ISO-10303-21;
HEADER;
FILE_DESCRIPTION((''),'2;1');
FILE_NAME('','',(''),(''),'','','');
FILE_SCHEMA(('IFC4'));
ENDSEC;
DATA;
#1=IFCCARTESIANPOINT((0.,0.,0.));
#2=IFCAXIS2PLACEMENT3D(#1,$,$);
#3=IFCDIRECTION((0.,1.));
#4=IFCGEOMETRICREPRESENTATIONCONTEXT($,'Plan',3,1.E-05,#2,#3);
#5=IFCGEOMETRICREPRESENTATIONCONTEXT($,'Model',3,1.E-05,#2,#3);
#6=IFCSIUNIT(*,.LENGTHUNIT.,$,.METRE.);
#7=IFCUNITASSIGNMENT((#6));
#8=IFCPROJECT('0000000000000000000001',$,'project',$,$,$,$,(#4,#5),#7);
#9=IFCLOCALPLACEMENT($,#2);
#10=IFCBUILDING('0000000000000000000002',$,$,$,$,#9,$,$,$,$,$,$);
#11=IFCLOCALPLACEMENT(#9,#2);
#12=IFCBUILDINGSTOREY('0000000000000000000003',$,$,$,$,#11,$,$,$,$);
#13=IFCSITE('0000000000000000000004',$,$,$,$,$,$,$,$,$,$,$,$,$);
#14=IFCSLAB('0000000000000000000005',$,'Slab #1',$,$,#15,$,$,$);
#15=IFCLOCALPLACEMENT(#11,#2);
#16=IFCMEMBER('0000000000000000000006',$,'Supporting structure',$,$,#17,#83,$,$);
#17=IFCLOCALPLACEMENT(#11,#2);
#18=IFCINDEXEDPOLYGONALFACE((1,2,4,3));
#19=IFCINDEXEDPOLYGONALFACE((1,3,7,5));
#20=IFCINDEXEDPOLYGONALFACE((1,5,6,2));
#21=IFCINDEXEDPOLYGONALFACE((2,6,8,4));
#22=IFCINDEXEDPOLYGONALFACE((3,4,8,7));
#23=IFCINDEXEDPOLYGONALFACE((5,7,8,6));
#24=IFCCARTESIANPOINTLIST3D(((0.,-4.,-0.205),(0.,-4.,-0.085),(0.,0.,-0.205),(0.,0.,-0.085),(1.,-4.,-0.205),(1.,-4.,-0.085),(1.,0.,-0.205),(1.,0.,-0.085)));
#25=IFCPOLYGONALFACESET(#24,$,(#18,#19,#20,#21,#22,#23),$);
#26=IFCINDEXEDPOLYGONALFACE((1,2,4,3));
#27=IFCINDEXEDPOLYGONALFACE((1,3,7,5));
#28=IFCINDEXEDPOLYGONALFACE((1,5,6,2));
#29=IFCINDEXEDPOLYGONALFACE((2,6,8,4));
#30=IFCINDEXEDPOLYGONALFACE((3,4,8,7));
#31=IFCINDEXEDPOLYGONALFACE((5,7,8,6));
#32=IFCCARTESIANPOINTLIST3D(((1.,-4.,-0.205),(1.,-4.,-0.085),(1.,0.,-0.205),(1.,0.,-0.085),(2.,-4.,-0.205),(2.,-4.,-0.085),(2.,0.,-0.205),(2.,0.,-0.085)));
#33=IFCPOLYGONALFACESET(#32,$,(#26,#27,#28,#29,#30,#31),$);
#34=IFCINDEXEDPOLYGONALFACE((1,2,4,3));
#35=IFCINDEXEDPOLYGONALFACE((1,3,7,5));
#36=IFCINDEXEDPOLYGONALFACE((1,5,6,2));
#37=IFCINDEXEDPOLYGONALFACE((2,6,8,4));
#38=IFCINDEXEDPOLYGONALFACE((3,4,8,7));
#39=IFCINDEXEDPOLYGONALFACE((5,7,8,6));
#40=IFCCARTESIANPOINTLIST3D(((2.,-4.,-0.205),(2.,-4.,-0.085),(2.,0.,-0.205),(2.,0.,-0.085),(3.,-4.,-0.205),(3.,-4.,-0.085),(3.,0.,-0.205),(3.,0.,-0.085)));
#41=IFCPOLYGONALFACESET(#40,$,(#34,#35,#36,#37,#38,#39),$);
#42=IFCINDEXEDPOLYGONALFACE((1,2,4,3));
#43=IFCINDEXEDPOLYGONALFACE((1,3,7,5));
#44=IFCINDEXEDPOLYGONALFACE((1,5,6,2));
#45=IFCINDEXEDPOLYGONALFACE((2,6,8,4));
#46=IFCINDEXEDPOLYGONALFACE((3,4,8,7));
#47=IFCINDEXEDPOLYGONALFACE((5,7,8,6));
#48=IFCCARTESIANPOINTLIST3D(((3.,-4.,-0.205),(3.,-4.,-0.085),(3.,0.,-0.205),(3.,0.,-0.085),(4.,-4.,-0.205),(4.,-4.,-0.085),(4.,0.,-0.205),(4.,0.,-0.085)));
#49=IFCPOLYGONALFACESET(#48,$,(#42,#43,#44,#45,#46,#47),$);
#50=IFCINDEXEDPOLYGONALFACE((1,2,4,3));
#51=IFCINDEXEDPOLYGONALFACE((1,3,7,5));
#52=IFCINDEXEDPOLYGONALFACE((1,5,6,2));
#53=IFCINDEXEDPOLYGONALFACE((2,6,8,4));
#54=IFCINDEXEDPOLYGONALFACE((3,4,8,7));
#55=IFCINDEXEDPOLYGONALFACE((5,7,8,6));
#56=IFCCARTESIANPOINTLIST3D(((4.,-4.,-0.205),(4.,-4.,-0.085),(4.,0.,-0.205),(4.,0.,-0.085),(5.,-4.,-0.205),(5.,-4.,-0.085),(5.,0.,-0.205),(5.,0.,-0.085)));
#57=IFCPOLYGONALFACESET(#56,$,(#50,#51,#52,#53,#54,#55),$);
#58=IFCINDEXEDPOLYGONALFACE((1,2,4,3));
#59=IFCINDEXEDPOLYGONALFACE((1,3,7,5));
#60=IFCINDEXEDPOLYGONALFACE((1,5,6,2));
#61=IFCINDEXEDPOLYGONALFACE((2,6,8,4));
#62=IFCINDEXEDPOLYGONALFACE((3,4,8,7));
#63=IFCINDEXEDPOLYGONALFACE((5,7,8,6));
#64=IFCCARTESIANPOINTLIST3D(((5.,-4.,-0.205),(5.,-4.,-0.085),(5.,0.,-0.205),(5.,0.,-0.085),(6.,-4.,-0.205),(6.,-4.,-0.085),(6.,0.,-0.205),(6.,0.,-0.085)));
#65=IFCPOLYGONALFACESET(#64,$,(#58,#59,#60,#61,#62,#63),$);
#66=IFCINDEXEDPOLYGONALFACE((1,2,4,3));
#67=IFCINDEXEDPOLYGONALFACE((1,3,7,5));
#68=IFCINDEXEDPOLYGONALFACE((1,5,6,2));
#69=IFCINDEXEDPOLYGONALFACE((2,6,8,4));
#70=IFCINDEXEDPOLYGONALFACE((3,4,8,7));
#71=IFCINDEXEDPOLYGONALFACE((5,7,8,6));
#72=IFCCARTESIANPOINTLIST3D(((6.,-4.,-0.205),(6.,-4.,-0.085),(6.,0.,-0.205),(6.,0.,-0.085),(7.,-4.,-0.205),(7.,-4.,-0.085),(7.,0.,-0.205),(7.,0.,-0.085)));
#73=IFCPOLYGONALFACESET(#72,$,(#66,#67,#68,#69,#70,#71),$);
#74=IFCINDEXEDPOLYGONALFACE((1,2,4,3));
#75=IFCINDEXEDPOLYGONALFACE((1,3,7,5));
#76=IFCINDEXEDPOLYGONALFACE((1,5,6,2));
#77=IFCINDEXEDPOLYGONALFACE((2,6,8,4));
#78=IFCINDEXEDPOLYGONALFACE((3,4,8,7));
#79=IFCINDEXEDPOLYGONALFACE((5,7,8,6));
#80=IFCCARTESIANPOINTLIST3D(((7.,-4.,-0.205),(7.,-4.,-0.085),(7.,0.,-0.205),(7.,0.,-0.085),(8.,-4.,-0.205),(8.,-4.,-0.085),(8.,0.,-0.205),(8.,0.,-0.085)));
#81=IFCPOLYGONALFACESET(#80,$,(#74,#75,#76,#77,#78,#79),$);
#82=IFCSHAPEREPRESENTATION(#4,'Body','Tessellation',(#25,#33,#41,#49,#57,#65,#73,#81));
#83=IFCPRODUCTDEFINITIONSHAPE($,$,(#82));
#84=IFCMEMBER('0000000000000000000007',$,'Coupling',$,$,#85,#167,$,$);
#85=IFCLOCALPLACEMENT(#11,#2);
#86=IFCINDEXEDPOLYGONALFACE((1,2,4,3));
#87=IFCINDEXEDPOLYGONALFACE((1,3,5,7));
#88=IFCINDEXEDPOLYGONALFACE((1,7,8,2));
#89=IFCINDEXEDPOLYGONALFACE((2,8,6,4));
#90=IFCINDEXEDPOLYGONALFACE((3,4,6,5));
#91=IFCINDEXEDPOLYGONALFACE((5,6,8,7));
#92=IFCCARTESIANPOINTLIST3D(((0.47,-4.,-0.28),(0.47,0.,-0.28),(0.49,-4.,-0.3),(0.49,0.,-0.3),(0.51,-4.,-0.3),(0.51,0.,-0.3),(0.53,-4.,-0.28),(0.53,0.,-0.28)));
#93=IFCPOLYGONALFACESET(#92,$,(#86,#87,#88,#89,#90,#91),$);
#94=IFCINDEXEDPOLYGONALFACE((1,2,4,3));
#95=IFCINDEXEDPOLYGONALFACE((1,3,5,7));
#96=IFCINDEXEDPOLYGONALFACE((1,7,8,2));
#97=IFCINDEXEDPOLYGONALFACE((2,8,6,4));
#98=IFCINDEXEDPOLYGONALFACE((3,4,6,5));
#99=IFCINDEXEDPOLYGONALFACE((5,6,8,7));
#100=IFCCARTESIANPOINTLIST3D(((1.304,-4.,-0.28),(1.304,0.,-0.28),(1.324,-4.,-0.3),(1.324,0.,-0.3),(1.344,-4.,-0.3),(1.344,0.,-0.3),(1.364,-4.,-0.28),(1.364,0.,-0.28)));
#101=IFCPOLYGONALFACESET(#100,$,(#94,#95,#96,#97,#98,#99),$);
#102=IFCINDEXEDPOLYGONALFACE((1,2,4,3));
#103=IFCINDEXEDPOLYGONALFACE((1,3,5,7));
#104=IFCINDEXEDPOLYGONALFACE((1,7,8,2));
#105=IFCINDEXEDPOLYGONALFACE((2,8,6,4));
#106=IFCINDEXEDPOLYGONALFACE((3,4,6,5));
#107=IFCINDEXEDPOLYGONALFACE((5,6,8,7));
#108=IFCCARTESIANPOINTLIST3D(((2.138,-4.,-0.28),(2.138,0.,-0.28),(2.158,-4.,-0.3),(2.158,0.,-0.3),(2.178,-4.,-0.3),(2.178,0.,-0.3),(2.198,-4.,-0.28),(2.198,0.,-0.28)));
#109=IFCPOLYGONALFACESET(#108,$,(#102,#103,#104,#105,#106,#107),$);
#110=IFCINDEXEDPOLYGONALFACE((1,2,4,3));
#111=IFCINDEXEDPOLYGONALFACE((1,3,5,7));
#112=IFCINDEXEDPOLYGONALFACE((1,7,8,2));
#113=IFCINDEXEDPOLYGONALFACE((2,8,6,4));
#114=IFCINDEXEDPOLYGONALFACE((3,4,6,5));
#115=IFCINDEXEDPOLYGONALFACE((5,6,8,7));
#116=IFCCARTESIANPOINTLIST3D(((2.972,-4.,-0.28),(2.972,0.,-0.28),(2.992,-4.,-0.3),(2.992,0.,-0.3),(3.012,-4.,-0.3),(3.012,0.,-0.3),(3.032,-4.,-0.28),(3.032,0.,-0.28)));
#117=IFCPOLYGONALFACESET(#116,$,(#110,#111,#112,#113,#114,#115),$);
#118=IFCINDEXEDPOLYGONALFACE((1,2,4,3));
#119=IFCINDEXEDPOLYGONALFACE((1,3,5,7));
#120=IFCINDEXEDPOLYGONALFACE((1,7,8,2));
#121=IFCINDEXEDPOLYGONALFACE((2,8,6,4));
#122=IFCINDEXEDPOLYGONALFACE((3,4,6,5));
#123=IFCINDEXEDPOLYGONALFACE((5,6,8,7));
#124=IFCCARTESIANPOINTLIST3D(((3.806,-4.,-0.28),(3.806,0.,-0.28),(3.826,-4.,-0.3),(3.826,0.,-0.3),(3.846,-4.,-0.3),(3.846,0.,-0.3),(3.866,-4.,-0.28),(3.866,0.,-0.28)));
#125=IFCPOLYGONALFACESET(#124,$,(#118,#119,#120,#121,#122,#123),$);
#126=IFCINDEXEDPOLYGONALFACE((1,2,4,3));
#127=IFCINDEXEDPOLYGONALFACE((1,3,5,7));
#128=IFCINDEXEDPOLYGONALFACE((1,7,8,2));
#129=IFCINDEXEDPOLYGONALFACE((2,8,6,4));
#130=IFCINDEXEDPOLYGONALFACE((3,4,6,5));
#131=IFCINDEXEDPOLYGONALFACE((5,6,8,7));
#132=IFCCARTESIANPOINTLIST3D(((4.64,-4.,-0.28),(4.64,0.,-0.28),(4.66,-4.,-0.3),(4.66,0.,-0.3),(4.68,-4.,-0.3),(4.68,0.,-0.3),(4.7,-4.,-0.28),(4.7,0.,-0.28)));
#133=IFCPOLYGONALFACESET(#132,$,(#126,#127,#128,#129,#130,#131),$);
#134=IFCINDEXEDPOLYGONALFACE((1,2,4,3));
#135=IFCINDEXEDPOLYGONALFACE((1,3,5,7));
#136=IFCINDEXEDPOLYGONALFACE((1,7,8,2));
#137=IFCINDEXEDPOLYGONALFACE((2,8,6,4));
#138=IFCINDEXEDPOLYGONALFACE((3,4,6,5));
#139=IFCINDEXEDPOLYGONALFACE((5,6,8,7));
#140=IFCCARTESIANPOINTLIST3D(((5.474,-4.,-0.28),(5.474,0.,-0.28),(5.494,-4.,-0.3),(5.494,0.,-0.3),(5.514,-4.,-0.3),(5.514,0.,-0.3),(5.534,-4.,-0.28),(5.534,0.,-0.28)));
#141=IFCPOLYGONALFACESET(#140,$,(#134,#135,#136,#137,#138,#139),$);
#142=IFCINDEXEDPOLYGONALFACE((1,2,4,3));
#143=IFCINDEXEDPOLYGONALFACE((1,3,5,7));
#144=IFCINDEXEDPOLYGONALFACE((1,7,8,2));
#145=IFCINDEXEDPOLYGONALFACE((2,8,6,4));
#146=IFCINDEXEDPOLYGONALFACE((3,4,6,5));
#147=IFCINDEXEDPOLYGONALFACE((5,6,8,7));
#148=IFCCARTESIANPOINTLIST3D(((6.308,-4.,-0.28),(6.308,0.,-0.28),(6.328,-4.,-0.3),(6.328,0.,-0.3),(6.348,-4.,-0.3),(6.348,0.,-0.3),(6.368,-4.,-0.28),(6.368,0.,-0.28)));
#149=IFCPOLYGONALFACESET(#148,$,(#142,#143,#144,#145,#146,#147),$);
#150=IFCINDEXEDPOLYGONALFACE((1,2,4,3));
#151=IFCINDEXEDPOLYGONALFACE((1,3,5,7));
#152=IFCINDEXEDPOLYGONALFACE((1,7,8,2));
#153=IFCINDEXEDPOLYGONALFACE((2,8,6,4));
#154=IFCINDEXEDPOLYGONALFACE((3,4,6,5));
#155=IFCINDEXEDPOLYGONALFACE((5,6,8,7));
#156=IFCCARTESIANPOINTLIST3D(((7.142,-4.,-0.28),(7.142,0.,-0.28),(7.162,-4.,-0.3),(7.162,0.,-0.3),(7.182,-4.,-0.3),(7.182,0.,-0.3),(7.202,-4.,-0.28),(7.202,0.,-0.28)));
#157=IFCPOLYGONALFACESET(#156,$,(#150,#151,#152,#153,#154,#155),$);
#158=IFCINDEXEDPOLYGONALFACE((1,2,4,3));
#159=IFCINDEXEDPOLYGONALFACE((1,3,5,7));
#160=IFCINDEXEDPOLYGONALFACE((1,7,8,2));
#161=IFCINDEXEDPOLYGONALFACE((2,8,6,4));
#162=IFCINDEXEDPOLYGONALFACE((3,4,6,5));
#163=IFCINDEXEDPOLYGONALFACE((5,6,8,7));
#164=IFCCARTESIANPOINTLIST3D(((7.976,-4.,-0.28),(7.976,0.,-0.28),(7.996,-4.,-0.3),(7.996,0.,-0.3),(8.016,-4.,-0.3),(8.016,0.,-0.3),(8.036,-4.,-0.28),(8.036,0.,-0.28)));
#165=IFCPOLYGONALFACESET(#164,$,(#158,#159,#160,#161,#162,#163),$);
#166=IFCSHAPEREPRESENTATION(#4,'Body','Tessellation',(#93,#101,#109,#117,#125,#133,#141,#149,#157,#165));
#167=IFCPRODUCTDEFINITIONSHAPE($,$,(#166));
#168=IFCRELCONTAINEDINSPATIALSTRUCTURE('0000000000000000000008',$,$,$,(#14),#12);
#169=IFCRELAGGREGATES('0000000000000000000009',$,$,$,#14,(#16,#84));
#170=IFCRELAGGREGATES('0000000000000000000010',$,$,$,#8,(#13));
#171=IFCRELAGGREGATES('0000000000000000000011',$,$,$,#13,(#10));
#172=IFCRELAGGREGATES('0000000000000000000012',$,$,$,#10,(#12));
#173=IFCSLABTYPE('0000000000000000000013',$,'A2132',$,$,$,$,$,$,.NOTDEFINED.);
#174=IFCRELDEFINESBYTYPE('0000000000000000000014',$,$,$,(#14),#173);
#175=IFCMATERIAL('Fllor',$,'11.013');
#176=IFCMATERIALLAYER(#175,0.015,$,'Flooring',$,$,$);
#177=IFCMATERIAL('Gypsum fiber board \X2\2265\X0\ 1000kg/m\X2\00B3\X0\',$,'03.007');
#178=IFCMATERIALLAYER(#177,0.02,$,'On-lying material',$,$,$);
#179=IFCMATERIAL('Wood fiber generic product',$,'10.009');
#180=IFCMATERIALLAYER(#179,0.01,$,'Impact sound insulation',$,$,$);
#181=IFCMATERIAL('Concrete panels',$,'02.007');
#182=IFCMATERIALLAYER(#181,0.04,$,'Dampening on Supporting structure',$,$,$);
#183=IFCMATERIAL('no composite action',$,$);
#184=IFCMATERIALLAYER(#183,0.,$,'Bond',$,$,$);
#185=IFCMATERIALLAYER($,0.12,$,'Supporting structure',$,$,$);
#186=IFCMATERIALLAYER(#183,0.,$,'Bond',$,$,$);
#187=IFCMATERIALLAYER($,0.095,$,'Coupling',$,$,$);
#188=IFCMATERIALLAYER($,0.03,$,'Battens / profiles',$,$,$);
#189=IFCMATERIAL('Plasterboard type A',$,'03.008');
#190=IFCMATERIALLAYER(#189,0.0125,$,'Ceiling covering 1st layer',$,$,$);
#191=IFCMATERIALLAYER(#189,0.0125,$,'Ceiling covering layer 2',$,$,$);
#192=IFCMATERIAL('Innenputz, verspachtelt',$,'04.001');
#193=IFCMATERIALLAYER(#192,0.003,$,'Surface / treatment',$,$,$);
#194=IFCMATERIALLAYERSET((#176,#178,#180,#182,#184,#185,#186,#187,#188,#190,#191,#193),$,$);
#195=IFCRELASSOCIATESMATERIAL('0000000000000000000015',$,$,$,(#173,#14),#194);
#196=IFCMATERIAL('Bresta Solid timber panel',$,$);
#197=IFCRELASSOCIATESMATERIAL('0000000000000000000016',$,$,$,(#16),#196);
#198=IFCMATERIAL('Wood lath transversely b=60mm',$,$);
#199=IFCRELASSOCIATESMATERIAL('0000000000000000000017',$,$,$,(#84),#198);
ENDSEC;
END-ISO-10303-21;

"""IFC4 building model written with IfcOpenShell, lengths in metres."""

from ifc_helpers import new_model, si_unit, direction, frame, frame_2d, origin, place, context, project, spatial, polyline, rectangle, outline, extrude, material, layer, layer_set, type_object, element, aggregate, save


model = new_model("IFC4")

# Units and contexts
plan_context = context("Plan", 3, precision=1e-05, world=origin(), true_north=direction((0.0, 1.0)))
model_context = context("Model", 3, precision=1e-05, world=origin(), true_north=direction((0.0, 1.0)))
ifc_project = project(units=[si_unit("LENGTHUNIT", "METRE")], contexts=[plan_context, model_context])

# Site, building, storey
site = spatial("IfcSite", under=ifc_project)
building_placement = place(None, origin())
building = spatial("IfcBuilding", under=site, at=building_placement)
storey_placement = place(building_placement, origin())
storey = spatial("IfcBuildingStorey", under=building, at=storey_placement)

# Slab, members
ifc_material_1 = material(Name="Fllor", Category="11.013")
ifc_layer_1 = layer(ifc_material_1, 0.015, Name="Flooring")
ifc_material_2 = material(Name="Gypsum fiber board ≥ 1000kg/m³", Category="03.007")
ifc_layer_2 = layer(ifc_material_2, 0.02, Name="On-lying material")
ifc_material_3 = material(Name="Wood fiber generic product", Category="10.009")
ifc_layer_3 = layer(ifc_material_3, 0.01, Name="Impact sound insulation")
ifc_material_4 = material(Name="Concrete panels", Category="02.007")
ifc_layer_4 = layer(ifc_material_4, 0.04, Name="Dampening on Supporting structure")
ifc_material_5 = material(Name="no composite action")
ifc_layer_5 = layer(ifc_material_5, 0.0, Name="Bond")
ifc_layer_6 = layer(None, 0.12, Name="Supporting structure")
ifc_layer_7 = layer(ifc_material_5, 0.0, Name="Bond")
ifc_layer_8 = layer(None, 0.095, Name="Coupling")
ifc_layer_9 = layer(None, 0.03, Name="Battens / profiles")
ifc_material_6 = material(Name="Plasterboard type A", Category="03.008")
ifc_layer_10 = layer(ifc_material_6, 0.0125, Name="Ceiling covering 1st layer")
ifc_layer_11 = layer(ifc_material_6, 0.0125, Name="Ceiling covering layer 2")
ifc_material_7 = material(Name="Innenputz, verspachtelt", Category="04.001")
ifc_layer_12 = layer(ifc_material_7, 0.003, Name="Surface / treatment")
ifc_layer_set = layer_set([ifc_layer_1, ifc_layer_2, ifc_layer_3, ifc_layer_4, ifc_layer_5, ifc_layer_6, ifc_layer_7, ifc_layer_8, ifc_layer_9, ifc_layer_10, ifc_layer_11, ifc_layer_12])
slab_type = type_object("IfcSlabType", Name="A2132", PredefinedType="NOTDEFINED", material=ifc_layer_set)
slab_placement = place(None, frame((0.0, 0.0, 0.0), z_axis=(0.0, 0.0, -1.0), x_axis=(1.0, 0.0, 0.0)))
slab = element("IfcSlab", 1, at=slab_placement, inside=storey, type_object=slab_type, material=ifc_layer_set, Name="Slab #1")
ifc_material_8 = material(Name="Bresta Solid timber panel")
member_1_placement = place(slab_placement, origin())
member_1 = element("IfcMember", 2, at=member_1_placement, material=ifc_material_8, Name="Supporting structure", context=plan_context, shape_type="SweptSolid", body=[
    extrude(rectangle(XDim=1.0, YDim=0.12, at=frame_2d((0.5, 0.06), x_axis=(1.0, 0.0))), frame((0.0, 4.0, 0.085), z_axis=(0.0, -1.0, 0.0), x_axis=(1.0, 0.0, 0.0)), (0.0, 0.0, 1.0), 4.0),
    extrude(rectangle(XDim=1.0, YDim=0.12, at=frame_2d((0.5, 0.06), x_axis=(1.0, 0.0))), frame((1.0, 4.0, 0.085), z_axis=(0.0, -1.0, 0.0), x_axis=(1.0, 0.0, 0.0)), (0.0, 0.0, 1.0), 4.0),
    extrude(rectangle(XDim=1.0, YDim=0.12, at=frame_2d((0.5, 0.06), x_axis=(1.0, 0.0))), frame((2.0, 4.0, 0.085), z_axis=(0.0, -1.0, 0.0), x_axis=(1.0, 0.0, 0.0)), (0.0, 0.0, 1.0), 4.0),
    extrude(rectangle(XDim=1.0, YDim=0.12, at=frame_2d((0.5, 0.06), x_axis=(1.0, 0.0))), frame((3.0, 4.0, 0.085), z_axis=(0.0, -1.0, 0.0), x_axis=(1.0, 0.0, 0.0)), (0.0, 0.0, 1.0), 4.0),
    extrude(rectangle(XDim=1.0, YDim=0.12, at=frame_2d((0.5, 0.06), x_axis=(1.0, 0.0))), frame((4.0, 4.0, 0.085), z_axis=(0.0, -1.0, 0.0), x_axis=(1.0, 0.0, 0.0)), (0.0, 0.0, 1.0), 4.0),
    extrude(rectangle(XDim=1.0, YDim=0.12, at=frame_2d((0.5, 0.06), x_axis=(1.0, 0.0))), frame((5.0, 4.0, 0.085), z_axis=(0.0, -1.0, 0.0), x_axis=(1.0, 0.0, 0.0)), (0.0, 0.0, 1.0), 4.0),
    extrude(rectangle(XDim=1.0, YDim=0.12, at=frame_2d((0.5, 0.06), x_axis=(1.0, 0.0))), frame((6.0, 4.0, 0.085), z_axis=(0.0, -1.0, 0.0), x_axis=(1.0, 0.0, 0.0)), (0.0, 0.0, 1.0), 4.0),
    extrude(rectangle(XDim=1.0, YDim=0.12, at=frame_2d((0.5, 0.06), x_axis=(1.0, 0.0))), frame((7.0, 4.0, 0.085), z_axis=(0.0, -1.0, 0.0), x_axis=(1.0, 0.0, 0.0)), (0.0, 0.0, 1.0), 4.0),
])
ifc_material_9 = material(Name="Wood lath transversely b=60mm")
member_2_placement = place(slab_placement, origin())
member_2 = element("IfcMember", 3, at=member_2_placement, material=ifc_material_9, Name="Coupling", context=plan_context, shape_type="SweptSolid", body=[
    extrude(outline(polyline([(0.0, 0.0), (0.06, 0.0), (0.04, 0.02), (0.02, 0.02), (0.0, 0.0)])), frame((0.47, 4.0, 0.28), z_axis=(0.0, -1.0, 0.0), x_axis=(1.0, 0.0, 0.0)), (0.0, 0.0, 1.0), 4.0),
    extrude(outline(polyline([(0.0, 0.0), (0.06, 0.0), (0.04, 0.02), (0.02, 0.02), (0.0, 0.0)])), frame((1.304, 4.0, 0.28), z_axis=(0.0, -1.0, 0.0), x_axis=(1.0, 0.0, 0.0)), (0.0, 0.0, 1.0), 4.0),
    extrude(outline(polyline([(0.0, 0.0), (0.06, 0.0), (0.04, 0.02), (0.02, 0.02), (0.0, 0.0)])), frame((2.138, 4.0, 0.28), z_axis=(0.0, -1.0, 0.0), x_axis=(1.0, 0.0, 0.0)), (0.0, 0.0, 1.0), 4.0),
    extrude(outline(polyline([(0.0, 0.0), (0.06, 0.0), (0.04, 0.02), (0.02, 0.02), (0.0, 0.0)])), frame((2.972, 4.0, 0.28), z_axis=(0.0, -1.0, 0.0), x_axis=(1.0, 0.0, 0.0)), (0.0, 0.0, 1.0), 4.0),
    extrude(outline(polyline([(0.0, 0.0), (0.06, 0.0), (0.04, 0.02), (0.02, 0.02), (0.0, 0.0)])), frame((3.806, 4.0, 0.28), z_axis=(0.0, -1.0, 0.0), x_axis=(1.0, 0.0, 0.0)), (0.0, 0.0, 1.0), 4.0),
    extrude(outline(polyline([(0.0, 0.0), (0.06, 0.0), (0.04, 0.02), (0.02, 0.02), (0.0, 0.0)])), frame((4.64, 4.0, 0.28), z_axis=(0.0, -1.0, 0.0), x_axis=(1.0, 0.0, 0.0)), (0.0, 0.0, 1.0), 4.0),
    extrude(outline(polyline([(0.0, 0.0), (0.06, 0.0), (0.04, 0.02), (0.02, 0.02), (0.0, 0.0)])), frame((5.474, 4.0, 0.28), z_axis=(0.0, -1.0, 0.0), x_axis=(1.0, 0.0, 0.0)), (0.0, 0.0, 1.0), 4.0),
    extrude(outline(polyline([(0.0, 0.0), (0.06, 0.0), (0.04, 0.02), (0.02, 0.02), (0.0, 0.0)])), frame((6.308, 4.0, 0.28), z_axis=(0.0, -1.0, 0.0), x_axis=(1.0, 0.0, 0.0)), (0.0, 0.0, 1.0), 4.0),
    extrude(outline(polyline([(0.0, 0.0), (0.06, 0.0), (0.04, 0.02), (0.02, 0.02), (0.0, 0.0)])), frame((7.142, 4.0, 0.28), z_axis=(0.0, -1.0, 0.0), x_axis=(1.0, 0.0, 0.0)), (0.0, 0.0, 1.0), 4.0),
    extrude(outline(polyline([(0.0, 0.0), (0.06, 0.0), (0.04, 0.02), (0.02, 0.02), (0.0, 0.0)])), frame((7.976, 4.0, 0.28), z_axis=(0.0, -1.0, 0.0), x_axis=(1.0, 0.0, 0.0)), (0.0, 0.0, 1.0), 4.0),
])
aggregate(slab, [member_1, member_2])

save(model, "model.ifc")
